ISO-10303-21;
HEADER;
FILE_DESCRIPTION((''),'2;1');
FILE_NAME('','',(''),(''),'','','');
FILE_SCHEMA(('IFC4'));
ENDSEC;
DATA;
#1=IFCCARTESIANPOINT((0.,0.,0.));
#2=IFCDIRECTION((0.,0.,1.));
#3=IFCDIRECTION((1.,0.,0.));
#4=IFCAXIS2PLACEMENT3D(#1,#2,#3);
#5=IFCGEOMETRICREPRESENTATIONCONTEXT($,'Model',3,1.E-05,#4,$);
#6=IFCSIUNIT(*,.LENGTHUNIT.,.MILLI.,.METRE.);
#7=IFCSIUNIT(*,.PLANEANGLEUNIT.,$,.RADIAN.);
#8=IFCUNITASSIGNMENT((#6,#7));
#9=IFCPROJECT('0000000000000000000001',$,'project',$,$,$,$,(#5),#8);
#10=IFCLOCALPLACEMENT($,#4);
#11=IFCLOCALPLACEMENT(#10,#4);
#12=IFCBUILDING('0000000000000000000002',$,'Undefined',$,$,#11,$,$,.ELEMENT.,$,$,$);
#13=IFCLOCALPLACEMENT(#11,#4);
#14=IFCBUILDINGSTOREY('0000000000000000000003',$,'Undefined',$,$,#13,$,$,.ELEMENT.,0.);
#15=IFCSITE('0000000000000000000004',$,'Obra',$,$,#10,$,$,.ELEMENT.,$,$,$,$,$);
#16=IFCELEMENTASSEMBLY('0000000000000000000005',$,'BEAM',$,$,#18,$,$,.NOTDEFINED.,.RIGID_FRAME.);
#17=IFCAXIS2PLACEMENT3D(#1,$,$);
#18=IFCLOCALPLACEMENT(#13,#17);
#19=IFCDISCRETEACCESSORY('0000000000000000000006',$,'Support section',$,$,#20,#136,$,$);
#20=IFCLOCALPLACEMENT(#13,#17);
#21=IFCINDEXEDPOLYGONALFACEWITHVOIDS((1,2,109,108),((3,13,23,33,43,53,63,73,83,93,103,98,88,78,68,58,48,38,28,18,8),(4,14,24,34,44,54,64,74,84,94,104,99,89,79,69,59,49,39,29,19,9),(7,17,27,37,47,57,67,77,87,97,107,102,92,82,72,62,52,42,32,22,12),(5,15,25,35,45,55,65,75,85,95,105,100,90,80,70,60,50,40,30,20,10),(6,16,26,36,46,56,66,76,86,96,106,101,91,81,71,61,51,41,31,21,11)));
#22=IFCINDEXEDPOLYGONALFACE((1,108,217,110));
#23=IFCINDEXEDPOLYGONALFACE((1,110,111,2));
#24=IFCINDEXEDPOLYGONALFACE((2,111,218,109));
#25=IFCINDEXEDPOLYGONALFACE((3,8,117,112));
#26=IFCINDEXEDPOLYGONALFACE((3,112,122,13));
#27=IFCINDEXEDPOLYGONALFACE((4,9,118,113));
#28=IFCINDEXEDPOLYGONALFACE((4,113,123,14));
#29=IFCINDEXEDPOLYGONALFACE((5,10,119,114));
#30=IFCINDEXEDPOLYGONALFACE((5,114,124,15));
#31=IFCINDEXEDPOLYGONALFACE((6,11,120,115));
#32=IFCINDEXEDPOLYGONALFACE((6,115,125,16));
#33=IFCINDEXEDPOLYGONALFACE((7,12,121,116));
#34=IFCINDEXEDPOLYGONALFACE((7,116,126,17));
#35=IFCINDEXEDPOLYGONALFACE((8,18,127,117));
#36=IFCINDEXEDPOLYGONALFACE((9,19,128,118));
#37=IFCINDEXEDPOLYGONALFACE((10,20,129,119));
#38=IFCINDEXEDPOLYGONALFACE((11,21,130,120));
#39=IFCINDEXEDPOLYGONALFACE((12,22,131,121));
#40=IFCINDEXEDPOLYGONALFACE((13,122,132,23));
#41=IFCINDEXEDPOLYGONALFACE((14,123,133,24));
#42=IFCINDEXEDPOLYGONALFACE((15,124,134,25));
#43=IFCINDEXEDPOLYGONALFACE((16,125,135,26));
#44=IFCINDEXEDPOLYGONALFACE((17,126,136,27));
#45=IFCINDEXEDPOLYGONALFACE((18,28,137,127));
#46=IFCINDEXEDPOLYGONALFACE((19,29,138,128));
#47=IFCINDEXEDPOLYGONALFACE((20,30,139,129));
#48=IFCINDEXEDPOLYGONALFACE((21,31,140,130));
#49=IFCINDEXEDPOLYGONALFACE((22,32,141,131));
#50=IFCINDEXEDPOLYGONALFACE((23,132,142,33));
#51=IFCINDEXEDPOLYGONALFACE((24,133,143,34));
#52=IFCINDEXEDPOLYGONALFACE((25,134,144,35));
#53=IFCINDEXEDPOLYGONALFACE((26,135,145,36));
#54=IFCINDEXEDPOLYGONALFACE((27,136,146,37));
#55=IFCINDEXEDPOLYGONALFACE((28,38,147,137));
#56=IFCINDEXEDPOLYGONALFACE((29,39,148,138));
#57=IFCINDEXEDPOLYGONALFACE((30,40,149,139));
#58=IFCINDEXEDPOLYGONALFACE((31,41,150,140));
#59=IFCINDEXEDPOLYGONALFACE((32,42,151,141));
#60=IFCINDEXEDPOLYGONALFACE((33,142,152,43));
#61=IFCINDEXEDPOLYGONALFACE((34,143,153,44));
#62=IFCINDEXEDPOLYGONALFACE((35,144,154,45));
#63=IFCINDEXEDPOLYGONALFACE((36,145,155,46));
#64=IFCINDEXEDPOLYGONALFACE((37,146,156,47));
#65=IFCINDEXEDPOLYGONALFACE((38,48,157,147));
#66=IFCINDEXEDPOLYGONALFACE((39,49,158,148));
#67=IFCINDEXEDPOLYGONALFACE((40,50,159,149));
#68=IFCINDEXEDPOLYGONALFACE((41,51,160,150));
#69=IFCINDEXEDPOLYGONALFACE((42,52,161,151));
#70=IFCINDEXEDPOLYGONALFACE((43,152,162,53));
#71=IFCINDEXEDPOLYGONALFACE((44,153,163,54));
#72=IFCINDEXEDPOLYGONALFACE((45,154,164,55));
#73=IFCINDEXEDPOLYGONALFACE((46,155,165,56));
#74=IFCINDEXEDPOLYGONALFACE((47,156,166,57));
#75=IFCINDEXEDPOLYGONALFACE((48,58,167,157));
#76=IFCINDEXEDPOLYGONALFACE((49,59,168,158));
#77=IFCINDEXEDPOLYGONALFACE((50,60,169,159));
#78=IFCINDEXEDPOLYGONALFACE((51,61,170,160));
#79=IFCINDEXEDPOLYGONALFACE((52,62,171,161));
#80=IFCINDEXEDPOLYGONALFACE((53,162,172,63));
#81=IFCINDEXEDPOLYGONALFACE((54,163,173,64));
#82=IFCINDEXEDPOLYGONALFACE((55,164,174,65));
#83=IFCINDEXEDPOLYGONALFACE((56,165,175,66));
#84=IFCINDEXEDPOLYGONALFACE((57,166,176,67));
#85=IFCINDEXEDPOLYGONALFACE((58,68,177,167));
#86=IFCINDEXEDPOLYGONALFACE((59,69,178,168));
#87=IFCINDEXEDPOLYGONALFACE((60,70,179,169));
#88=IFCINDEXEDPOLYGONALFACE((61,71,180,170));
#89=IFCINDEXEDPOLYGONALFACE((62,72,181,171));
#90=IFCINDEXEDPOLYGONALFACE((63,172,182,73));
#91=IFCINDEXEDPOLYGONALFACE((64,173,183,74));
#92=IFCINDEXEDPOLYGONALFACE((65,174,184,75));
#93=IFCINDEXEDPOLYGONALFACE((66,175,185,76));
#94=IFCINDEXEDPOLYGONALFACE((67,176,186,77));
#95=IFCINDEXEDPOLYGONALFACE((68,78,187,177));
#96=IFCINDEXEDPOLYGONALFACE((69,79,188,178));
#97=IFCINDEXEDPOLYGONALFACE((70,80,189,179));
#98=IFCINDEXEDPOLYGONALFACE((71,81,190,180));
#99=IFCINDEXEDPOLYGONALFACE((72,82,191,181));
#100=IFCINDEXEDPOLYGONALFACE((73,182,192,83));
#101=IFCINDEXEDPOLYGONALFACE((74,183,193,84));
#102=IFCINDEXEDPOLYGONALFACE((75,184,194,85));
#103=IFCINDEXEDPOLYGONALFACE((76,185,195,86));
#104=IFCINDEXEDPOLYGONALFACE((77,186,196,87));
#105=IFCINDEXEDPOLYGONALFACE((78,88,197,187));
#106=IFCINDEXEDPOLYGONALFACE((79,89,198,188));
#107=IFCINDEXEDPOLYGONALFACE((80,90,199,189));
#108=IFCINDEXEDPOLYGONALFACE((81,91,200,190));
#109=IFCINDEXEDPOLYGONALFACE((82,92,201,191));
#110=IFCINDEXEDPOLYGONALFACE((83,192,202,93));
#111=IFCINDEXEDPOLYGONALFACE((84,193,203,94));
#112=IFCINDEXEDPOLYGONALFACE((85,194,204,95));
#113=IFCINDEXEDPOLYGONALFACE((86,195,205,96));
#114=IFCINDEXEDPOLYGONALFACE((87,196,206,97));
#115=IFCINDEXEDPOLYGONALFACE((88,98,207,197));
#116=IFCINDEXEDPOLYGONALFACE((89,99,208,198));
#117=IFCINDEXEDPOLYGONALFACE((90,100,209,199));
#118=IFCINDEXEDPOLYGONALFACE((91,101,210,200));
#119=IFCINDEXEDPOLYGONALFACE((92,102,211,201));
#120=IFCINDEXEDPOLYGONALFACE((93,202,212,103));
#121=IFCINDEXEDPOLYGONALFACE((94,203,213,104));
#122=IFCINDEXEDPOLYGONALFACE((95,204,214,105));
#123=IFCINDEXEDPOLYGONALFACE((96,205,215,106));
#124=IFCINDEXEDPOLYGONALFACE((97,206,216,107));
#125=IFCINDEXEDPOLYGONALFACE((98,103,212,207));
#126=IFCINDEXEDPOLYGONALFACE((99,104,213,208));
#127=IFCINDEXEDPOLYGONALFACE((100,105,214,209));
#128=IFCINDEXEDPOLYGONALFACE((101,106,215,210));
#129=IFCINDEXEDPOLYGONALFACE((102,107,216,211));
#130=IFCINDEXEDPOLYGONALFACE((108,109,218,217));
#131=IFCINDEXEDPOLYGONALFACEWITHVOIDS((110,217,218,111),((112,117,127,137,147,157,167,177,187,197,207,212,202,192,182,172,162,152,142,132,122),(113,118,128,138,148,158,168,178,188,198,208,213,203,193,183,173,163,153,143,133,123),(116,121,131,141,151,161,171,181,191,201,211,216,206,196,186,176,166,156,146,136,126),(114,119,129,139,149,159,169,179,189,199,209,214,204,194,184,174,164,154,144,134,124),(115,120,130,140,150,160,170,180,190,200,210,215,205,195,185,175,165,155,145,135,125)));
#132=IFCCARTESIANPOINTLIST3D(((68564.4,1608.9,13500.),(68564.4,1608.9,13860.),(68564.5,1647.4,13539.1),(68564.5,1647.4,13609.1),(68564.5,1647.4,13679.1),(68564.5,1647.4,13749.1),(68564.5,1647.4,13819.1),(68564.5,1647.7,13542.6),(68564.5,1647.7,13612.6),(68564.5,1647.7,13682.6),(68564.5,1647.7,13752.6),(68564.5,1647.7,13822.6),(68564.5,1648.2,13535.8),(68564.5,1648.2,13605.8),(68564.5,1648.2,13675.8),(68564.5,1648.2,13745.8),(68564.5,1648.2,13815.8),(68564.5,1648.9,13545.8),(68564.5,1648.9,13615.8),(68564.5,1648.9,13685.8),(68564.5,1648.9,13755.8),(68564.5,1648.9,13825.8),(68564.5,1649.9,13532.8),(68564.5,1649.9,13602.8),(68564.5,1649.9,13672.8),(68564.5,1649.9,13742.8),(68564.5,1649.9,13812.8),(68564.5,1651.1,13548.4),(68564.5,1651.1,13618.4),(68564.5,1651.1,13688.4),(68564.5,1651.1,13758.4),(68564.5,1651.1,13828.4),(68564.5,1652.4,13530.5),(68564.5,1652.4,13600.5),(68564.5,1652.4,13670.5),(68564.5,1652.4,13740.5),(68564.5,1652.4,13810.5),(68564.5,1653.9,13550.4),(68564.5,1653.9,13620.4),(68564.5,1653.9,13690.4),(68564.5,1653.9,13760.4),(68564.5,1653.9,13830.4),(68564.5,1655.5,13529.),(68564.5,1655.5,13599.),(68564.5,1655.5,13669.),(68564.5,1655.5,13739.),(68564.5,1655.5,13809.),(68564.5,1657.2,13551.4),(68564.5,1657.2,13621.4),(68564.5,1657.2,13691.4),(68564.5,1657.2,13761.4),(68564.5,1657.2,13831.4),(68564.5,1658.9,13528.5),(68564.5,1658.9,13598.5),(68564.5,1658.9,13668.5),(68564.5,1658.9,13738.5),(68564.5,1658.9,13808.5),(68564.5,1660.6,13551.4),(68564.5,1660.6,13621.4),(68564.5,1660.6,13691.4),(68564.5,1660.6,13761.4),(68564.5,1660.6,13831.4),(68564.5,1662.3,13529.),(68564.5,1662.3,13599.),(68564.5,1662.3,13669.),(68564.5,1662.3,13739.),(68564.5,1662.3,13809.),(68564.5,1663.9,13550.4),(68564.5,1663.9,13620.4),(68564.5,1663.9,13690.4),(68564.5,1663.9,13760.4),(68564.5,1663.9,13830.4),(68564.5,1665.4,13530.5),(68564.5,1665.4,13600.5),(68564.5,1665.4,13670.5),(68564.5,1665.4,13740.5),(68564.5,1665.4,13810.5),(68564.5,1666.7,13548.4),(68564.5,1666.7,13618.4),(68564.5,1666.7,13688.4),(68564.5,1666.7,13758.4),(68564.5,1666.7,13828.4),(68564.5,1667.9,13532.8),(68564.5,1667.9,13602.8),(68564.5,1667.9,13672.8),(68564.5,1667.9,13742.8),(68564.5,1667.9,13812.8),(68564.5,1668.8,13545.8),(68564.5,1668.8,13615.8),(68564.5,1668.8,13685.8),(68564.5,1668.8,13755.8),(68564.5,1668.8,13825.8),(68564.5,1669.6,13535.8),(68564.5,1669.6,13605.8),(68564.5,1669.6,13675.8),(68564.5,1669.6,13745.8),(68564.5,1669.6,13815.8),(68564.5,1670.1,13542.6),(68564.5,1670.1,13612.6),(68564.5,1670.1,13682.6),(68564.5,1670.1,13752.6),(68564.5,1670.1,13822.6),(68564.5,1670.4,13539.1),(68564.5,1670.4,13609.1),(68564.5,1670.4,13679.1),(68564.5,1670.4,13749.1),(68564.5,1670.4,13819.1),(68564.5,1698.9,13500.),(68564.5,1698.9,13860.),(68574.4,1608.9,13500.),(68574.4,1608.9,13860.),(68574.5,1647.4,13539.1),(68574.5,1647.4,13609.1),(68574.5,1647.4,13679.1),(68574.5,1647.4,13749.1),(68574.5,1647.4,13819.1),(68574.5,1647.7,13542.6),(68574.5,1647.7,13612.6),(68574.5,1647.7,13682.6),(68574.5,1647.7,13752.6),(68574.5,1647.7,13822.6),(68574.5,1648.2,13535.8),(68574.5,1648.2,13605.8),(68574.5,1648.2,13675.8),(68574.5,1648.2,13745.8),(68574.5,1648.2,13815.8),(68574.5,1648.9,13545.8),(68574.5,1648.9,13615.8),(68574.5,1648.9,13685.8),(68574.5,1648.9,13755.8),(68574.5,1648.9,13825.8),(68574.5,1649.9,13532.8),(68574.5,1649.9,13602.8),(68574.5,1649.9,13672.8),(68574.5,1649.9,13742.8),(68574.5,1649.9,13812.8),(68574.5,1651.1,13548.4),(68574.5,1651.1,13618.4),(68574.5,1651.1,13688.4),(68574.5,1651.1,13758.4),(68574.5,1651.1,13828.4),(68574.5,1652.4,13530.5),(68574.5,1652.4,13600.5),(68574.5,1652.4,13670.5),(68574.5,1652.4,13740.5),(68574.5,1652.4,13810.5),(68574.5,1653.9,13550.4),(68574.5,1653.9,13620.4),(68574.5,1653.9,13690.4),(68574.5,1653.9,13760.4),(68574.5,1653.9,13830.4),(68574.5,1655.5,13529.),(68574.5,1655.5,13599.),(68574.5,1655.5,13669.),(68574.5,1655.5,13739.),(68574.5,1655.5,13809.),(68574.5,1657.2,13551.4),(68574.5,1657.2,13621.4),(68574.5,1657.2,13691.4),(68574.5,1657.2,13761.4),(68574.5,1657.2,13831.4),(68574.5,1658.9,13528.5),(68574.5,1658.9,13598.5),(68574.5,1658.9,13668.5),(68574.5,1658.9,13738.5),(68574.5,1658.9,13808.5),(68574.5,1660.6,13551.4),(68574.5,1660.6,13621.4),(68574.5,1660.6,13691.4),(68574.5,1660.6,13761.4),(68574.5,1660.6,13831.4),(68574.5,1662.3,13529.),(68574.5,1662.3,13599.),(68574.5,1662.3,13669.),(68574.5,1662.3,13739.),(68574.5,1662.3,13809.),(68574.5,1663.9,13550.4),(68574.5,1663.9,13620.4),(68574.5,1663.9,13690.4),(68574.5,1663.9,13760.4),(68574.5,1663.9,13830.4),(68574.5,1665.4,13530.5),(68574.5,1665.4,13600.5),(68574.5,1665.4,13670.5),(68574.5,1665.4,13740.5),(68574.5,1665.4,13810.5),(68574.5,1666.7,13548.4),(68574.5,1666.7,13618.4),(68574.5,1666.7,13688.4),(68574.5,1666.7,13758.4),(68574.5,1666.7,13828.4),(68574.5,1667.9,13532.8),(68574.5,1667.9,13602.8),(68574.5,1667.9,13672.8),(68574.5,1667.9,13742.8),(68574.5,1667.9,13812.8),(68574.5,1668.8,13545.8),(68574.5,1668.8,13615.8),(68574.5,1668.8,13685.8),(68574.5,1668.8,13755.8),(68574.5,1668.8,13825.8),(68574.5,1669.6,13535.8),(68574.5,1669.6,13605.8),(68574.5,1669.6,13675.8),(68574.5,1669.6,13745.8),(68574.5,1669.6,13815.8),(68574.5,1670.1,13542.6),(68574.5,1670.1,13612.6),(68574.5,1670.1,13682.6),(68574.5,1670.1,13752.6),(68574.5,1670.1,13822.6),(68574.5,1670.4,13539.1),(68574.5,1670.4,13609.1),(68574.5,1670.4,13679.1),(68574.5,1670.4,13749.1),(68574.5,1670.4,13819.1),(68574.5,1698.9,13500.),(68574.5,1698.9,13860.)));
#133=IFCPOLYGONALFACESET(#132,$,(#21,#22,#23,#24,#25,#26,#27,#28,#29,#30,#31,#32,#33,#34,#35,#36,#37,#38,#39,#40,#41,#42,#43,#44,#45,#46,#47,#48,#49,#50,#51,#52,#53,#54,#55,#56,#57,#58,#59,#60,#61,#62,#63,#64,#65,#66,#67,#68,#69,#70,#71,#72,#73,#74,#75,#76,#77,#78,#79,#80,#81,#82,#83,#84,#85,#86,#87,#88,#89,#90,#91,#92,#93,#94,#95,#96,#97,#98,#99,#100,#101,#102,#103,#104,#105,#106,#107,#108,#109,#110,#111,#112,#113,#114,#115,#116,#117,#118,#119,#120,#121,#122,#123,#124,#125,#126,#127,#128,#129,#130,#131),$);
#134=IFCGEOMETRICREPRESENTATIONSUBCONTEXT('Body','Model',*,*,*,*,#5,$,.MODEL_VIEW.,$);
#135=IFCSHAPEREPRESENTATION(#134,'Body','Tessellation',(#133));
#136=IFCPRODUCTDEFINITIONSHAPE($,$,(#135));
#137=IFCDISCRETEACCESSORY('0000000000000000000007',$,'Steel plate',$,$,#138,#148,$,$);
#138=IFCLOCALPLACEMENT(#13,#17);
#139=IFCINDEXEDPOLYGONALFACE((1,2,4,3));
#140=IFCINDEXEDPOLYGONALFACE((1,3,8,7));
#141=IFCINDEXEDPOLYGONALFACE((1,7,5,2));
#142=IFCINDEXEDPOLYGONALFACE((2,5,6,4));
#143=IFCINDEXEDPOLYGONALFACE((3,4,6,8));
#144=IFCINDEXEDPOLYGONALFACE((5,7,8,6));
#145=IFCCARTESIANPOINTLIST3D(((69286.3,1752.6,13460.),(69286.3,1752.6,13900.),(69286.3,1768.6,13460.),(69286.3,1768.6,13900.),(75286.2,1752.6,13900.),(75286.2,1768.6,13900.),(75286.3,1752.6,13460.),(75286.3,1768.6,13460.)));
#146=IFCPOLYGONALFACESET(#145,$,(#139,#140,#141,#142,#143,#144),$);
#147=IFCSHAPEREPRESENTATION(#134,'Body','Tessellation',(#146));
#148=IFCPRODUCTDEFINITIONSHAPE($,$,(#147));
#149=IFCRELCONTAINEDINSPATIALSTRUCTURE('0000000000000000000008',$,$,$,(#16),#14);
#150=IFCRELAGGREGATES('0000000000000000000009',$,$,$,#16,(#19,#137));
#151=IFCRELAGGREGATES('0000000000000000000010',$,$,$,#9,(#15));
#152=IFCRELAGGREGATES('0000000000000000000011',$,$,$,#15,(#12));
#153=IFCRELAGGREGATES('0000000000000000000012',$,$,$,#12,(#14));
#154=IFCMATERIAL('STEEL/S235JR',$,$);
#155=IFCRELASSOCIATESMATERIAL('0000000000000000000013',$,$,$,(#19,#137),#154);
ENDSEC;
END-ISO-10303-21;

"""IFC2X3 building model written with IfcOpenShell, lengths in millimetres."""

from ifc_helpers import new_model, si_unit, frame, origin_with_axes, origin_2d_with_axis, place, context, subcontext, project, spatial, polyline, rectangle, circle, outline, extrude, source, transform, mapped, material, element, aggregate, save


model = new_model("IFC2X3")

# Units and contexts
model_context = context("Model", 3, precision=1e-05, world=origin_with_axes())
body_context = subcontext(model_context, "Body", "Model", "MODEL_VIEW")
ifc_project = project(units=[si_unit("LENGTHUNIT", "METRE", prefix="MILLI"), si_unit("PLANEANGLEUNIT", "RADIAN")], contexts=[model_context])

# Site, building, storey
site_placement = place(None, origin_with_axes())
site = spatial("IfcSite", under=ifc_project, at=site_placement, Name="Obra", CompositionType="ELEMENT")
building_placement = place(site_placement, origin_with_axes())
building = spatial("IfcBuilding", under=site, at=building_placement, Name="Undefined", CompositionType="ELEMENT")
storey_placement = place(building_placement, origin_with_axes())
storey = spatial("IfcBuildingStorey", under=building, at=storey_placement, Name="Undefined", CompositionType="ELEMENT", Elevation=0.0)

# Shared definitions
ifc_material_1 = material(Name="STEEL/S235JR")

# Element assembly
assembly_1_placement = place(storey_placement, origin_with_axes())
assembly_1 = element("IfcElementAssembly", 1, at=assembly_1_placement, inside=storey, Name="BEAM", AssemblyPlace="NOTDEFINED", PredefinedType="RIGID_FRAME")

# Discrete accessory, opening
discrete_accessory_1_placement = place(assembly_1_placement, frame((68569.5, 1653.9, 13500.0), z_axis=(0.0, 0.0, 1.0), x_axis=(-0.000708, -1.0, 0.0)))
discrete_accessory_1 = element("IfcDiscreteAccessory", 2, at=discrete_accessory_1_placement, material=ifc_material_1, Name="Support section", context=body_context, shape_type="SweptSolid", body=[
    extrude(rectangle(XDim=10.0, YDim=90.0, at=origin_2d_with_axis()), frame((0.0, 0.0, 360.0), z_axis=(0.0, 0.0, -1.0), x_axis=(0.0, 1.0, 0.0)), (0.0, 0.0, 1.0), 360.0),
])
shared_shape_1 = source(origin_with_axes(), body_context, "Body", "SweptSolid", [
    extrude(circle(Radius=11.5, at=origin_2d_with_axis()), frame((0.0, -15.8, 0.0), z_axis=(0.0, 1.0, 0.0), x_axis=(1.0, 0.0, 0.0)), (0.0, 0.0, 1.0), 10.2),
])
opening_1_placement = place(assembly_1_placement, frame((68558.7, 1618.9, 13900.0), z_axis=(0.000708, 1.0, 0.0), x_axis=(0.0, 0.0, -1.0)))
element("IfcOpeningElement", 3, at=opening_1_placement, cuts=discrete_accessory_1, ObjectType="Opening", context=body_context, shape_type="MappedRepresentation", body=[
    mapped(shared_shape_1, transform((80.0, 0.0, 40.0))),
    mapped(shared_shape_1, transform((150.0, 0.0, 40.0))),
    mapped(shared_shape_1, transform((220.0, 0.0, 40.0))),
    mapped(shared_shape_1, transform((290.0, 0.0, 40.0))),
    mapped(shared_shape_1, transform((360.0, 0.0, 40.0))),
])

# Discrete accessory
discrete_accessory_2_placement = place(assembly_1_placement, frame((69286.3, 1760.6, 13900.0), z_axis=(0.0, -1.0, 0.0), x_axis=(0.0, 0.0, -1.0)))
discrete_accessory_2 = element("IfcDiscreteAccessory", 4, at=discrete_accessory_2_placement, material=ifc_material_1, Name="Steel plate", context=body_context, shape_type="SweptSolid", body=[
    extrude(outline(polyline([(0.0, 0.0), (440.0, 0.0), (440.0, 6000.0), (0.0, 5999.9), (0.0, 0.0)])), frame((0.0, 0.0, -8.0), z_axis=(0.0, 0.0, 1.0), x_axis=(1.0, 0.0, 0.0)), (0.0, 0.0, 1.0), 16.0),
])

aggregate(assembly_1, [discrete_accessory_1, discrete_accessory_2])

save(model, "model.ifc")
